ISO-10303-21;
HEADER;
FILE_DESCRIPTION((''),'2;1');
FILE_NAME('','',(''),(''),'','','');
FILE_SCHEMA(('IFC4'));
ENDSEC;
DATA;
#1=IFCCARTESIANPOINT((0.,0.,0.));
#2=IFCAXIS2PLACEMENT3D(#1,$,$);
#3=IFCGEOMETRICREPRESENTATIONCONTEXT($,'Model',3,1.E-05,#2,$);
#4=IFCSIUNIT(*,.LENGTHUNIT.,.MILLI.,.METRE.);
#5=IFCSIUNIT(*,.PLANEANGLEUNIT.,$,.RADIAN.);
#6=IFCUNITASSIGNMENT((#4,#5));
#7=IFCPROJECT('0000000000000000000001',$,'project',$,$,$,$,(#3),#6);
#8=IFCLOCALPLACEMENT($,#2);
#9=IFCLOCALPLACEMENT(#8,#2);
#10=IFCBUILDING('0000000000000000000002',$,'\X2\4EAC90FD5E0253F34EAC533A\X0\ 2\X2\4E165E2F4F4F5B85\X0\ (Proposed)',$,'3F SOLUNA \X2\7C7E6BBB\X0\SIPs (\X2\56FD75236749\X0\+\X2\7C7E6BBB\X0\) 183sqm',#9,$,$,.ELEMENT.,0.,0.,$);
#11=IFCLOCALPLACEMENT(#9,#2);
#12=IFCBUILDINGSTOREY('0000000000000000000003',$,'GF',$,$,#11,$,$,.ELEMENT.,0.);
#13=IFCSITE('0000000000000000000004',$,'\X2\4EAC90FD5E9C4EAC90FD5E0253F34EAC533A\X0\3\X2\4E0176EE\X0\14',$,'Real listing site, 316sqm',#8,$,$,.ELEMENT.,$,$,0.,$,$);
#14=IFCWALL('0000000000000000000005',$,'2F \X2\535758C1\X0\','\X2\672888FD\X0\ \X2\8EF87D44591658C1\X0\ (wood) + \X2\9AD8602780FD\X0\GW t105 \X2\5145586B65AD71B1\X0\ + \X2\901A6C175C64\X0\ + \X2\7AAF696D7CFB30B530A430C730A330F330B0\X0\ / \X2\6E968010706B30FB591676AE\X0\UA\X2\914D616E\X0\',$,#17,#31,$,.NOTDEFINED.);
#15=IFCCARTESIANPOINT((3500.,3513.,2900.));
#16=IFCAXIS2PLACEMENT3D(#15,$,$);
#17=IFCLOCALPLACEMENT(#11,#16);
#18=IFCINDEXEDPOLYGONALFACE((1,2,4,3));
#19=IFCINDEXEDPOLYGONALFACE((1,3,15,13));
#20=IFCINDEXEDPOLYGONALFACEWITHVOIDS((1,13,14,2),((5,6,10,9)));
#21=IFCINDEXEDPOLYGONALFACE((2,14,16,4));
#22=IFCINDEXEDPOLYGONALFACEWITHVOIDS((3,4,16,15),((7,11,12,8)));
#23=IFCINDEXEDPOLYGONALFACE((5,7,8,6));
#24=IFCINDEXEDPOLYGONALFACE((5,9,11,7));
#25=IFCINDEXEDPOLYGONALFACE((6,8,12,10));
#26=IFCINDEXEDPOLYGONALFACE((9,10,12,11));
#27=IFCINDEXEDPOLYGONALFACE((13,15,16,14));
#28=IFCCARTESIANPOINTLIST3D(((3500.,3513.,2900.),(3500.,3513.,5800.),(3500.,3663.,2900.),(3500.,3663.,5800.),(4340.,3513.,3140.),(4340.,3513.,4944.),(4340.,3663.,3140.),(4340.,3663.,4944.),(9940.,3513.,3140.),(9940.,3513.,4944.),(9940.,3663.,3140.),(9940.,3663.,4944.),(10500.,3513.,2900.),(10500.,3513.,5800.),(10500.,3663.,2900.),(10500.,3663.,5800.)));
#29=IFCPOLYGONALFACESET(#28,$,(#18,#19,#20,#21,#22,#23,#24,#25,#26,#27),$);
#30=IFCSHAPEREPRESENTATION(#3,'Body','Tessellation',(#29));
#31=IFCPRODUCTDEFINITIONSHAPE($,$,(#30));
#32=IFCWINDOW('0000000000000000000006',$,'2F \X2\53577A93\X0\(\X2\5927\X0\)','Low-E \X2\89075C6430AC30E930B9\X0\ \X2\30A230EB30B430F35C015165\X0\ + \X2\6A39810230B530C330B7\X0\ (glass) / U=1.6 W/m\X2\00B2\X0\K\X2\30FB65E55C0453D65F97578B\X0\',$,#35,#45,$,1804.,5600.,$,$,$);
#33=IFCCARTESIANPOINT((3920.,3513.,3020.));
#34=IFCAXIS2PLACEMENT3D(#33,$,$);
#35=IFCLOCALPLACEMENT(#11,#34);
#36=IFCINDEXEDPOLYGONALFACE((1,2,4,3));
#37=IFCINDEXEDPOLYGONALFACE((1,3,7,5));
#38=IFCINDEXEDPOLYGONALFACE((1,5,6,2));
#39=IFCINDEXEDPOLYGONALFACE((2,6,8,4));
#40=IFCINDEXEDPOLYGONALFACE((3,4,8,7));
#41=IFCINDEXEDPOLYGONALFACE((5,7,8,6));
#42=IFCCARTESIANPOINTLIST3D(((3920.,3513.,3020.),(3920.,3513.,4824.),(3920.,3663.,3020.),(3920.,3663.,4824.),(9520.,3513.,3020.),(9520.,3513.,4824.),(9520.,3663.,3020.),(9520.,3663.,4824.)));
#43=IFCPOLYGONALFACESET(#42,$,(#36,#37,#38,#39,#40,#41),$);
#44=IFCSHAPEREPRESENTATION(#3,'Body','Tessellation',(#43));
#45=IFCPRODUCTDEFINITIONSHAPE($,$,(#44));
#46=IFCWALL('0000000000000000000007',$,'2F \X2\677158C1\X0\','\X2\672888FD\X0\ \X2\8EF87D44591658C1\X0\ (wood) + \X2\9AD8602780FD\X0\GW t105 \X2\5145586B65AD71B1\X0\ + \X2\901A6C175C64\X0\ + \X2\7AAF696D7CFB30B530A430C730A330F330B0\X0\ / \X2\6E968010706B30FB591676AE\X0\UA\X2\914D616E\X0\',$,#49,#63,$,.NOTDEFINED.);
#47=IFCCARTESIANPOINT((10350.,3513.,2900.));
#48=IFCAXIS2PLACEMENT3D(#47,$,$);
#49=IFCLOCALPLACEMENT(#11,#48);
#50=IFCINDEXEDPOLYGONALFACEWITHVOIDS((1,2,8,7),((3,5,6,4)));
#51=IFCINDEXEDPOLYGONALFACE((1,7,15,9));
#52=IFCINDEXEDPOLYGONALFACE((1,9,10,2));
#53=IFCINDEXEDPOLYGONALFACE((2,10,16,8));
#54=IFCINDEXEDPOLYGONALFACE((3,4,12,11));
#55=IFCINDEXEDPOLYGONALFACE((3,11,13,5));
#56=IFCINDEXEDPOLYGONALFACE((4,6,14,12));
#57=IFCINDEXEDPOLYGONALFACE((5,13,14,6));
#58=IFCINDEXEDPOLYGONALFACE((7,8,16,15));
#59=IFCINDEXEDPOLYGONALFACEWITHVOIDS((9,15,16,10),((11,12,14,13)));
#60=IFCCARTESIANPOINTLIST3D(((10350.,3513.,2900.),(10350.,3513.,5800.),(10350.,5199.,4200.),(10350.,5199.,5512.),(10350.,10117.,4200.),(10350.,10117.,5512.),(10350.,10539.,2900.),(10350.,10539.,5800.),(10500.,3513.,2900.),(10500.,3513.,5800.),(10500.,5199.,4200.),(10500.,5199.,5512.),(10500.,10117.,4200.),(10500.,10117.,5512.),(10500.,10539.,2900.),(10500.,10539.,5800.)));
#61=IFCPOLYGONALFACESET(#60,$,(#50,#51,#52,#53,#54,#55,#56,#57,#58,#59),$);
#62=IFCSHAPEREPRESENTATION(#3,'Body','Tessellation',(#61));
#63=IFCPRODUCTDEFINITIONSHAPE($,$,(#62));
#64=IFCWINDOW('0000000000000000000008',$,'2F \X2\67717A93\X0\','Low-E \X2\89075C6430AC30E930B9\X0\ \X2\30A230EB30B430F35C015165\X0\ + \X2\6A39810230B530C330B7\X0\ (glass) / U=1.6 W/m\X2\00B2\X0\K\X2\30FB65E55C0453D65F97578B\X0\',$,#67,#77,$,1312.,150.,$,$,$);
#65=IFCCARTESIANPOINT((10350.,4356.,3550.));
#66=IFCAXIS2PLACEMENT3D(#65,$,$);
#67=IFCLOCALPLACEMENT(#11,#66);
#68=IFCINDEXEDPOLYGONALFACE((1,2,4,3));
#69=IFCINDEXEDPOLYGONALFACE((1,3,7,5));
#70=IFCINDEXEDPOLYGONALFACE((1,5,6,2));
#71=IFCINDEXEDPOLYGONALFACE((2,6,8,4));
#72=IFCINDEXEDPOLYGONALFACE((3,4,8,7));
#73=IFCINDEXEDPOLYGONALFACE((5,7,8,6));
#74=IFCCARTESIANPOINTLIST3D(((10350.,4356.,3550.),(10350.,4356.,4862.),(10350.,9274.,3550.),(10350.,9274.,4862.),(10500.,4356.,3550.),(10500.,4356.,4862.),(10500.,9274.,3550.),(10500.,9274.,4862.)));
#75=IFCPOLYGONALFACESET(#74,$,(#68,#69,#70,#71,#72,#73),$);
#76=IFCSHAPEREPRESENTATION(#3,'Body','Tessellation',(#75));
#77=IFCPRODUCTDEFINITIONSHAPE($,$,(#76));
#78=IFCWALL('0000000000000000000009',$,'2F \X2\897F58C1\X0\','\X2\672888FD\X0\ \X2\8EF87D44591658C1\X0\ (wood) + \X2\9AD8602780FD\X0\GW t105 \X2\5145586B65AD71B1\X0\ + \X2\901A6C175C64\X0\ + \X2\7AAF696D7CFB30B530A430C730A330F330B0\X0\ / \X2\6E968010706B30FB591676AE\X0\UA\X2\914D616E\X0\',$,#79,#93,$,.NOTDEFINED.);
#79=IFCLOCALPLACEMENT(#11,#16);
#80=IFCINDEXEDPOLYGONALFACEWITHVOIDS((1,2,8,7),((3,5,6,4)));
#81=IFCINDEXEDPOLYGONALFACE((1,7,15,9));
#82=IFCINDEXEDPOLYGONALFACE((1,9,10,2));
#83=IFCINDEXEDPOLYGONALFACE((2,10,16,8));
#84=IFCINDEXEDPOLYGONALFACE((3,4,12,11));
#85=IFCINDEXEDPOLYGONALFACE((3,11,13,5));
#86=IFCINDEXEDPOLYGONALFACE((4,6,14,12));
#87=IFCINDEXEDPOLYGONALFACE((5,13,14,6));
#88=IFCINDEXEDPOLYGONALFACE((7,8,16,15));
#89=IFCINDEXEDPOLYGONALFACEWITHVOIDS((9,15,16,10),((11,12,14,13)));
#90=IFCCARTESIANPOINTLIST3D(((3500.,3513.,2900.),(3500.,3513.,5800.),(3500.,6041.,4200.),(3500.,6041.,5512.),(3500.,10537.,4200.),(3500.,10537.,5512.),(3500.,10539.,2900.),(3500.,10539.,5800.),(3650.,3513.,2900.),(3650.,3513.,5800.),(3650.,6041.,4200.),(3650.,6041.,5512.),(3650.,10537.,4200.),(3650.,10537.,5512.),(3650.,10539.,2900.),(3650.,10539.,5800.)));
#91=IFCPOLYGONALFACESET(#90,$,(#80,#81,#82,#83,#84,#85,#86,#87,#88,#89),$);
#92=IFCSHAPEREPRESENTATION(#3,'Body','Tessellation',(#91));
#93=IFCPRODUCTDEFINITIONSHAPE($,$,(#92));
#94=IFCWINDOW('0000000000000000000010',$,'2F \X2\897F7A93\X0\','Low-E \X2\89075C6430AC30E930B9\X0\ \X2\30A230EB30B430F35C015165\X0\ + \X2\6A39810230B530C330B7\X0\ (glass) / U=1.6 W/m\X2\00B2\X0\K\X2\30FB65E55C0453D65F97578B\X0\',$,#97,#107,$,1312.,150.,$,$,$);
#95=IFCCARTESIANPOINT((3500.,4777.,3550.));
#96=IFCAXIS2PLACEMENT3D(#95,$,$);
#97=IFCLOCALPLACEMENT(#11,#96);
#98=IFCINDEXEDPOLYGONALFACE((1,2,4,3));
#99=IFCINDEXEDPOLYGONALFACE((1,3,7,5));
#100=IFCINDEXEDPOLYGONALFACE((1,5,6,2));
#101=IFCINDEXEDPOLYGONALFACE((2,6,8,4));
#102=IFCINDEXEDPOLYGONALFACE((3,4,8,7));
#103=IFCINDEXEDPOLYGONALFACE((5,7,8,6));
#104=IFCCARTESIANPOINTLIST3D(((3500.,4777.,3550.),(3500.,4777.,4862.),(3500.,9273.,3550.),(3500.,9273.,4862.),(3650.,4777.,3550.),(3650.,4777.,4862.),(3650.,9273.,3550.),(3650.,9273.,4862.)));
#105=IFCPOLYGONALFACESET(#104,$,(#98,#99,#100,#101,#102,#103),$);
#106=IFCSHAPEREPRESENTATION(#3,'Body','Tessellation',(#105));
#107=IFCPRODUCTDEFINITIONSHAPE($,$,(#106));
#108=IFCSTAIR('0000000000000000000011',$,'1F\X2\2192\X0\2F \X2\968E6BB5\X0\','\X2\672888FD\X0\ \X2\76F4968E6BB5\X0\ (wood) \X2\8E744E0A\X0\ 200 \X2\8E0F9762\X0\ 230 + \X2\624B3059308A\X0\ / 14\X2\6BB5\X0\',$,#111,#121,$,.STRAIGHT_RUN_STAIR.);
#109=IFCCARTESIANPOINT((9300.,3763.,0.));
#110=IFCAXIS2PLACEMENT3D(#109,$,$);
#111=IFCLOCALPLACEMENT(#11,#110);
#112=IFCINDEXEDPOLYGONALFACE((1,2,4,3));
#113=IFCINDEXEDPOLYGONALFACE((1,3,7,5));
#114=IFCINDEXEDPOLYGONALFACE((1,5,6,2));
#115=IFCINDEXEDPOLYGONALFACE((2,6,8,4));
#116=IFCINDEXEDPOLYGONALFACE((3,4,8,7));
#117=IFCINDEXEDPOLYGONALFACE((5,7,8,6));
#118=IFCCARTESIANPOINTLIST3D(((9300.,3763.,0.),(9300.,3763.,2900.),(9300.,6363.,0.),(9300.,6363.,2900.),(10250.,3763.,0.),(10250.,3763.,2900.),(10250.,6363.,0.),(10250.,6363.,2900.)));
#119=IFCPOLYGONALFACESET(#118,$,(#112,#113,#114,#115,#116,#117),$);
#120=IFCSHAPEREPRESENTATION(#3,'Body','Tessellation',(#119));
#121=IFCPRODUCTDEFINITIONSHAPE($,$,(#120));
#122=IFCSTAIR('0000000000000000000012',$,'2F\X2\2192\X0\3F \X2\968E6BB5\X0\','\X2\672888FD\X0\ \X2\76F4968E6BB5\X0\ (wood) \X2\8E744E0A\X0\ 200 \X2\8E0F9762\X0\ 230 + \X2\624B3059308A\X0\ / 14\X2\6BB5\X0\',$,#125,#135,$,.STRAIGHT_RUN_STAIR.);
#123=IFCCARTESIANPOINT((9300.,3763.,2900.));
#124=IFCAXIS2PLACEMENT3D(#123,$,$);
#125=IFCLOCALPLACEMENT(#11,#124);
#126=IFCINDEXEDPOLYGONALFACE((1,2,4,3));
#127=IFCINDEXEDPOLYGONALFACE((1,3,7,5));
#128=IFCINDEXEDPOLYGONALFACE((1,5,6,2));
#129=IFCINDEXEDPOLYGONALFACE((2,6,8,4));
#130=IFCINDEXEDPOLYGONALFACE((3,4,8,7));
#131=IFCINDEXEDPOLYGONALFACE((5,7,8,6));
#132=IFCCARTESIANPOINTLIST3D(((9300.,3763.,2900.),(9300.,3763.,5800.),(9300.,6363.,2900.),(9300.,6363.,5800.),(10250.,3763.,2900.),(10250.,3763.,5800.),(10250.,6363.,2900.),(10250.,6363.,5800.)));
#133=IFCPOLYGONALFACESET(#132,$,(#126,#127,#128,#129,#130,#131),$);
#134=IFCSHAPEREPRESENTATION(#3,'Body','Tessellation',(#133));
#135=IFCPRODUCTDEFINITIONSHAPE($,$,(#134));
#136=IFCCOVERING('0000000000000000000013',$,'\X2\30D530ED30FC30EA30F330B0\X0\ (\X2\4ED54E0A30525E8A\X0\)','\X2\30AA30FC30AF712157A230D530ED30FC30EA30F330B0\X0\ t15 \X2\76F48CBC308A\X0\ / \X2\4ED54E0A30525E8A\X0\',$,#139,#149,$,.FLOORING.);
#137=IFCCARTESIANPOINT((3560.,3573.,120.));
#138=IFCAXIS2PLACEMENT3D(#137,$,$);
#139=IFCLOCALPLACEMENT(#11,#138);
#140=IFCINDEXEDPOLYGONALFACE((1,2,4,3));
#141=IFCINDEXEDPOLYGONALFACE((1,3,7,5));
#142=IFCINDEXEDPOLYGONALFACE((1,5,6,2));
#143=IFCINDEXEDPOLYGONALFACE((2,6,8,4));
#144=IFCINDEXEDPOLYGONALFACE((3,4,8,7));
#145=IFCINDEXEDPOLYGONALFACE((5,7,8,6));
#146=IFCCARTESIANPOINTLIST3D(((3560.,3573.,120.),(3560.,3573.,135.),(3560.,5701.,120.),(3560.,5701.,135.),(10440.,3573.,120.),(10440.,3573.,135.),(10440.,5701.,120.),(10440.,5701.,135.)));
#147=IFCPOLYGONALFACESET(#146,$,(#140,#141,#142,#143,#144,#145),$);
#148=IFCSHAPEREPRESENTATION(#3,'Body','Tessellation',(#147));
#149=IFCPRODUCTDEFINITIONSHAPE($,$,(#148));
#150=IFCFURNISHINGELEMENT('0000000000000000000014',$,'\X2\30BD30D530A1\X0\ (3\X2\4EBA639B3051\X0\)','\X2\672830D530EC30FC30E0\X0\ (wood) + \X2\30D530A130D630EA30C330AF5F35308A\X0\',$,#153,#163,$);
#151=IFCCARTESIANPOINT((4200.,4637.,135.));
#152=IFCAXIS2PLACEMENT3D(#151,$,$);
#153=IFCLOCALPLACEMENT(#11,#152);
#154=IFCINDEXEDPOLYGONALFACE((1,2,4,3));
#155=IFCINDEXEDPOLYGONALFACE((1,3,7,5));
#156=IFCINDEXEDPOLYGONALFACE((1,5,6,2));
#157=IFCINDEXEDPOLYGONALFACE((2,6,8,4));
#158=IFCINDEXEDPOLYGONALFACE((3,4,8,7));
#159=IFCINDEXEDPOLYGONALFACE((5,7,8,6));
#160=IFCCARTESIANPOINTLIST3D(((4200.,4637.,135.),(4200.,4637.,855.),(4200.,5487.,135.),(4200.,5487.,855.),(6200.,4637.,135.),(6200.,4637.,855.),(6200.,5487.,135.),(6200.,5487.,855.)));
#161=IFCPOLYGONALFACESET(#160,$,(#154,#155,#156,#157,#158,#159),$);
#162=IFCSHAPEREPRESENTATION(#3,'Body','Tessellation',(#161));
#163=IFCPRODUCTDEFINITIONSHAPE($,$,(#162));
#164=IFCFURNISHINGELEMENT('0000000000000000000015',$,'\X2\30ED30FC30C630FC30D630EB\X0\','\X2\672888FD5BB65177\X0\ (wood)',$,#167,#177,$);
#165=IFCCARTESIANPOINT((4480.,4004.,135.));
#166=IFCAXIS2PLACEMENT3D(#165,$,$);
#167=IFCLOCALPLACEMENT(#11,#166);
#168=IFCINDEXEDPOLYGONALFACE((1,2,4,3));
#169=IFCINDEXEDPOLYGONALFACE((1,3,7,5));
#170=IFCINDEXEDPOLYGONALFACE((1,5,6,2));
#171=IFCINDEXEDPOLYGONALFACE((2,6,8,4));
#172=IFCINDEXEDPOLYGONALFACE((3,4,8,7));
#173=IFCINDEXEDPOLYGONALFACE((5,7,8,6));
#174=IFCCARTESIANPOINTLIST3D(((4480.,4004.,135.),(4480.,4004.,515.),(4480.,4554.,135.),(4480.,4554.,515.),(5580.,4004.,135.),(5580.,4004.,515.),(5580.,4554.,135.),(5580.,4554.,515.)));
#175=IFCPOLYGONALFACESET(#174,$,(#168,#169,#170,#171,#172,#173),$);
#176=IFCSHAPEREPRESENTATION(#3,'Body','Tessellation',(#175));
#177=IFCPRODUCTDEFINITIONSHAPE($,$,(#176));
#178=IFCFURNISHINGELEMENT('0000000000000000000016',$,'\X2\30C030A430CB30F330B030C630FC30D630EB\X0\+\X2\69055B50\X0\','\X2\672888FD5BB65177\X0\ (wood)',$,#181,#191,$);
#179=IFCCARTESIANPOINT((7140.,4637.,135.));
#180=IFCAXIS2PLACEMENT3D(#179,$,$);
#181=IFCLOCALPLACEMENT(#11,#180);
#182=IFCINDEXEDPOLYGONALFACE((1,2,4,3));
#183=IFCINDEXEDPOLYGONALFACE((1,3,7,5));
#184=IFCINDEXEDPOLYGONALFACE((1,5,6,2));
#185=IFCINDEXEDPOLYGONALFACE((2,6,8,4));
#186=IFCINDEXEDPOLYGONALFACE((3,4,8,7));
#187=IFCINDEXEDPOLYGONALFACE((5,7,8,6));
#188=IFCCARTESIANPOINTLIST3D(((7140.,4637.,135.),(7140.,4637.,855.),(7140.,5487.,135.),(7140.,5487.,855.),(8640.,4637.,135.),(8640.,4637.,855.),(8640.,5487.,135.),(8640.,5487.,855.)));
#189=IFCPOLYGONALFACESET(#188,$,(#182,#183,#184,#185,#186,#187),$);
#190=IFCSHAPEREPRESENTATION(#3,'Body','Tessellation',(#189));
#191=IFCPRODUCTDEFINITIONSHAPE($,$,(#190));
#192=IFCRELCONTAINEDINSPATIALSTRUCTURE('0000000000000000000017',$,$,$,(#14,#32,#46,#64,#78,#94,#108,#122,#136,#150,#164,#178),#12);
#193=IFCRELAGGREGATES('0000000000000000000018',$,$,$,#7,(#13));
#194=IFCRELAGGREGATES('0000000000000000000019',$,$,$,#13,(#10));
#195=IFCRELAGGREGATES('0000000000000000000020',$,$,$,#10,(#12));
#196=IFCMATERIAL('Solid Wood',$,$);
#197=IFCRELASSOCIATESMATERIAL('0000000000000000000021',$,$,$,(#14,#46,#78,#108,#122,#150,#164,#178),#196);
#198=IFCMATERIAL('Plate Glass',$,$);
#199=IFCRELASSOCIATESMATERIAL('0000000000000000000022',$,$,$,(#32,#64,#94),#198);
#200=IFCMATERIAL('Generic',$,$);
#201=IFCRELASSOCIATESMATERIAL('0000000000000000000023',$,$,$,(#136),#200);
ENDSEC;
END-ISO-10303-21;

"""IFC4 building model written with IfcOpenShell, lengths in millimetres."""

from ifc_helpers import new_model, si_unit, frame, frame_2d, origin, place, context, project, spatial, rectangle, extrude, material, element, fill, save


model = new_model("IFC4")

# Units and contexts
model_context = context("Model", 3, precision=1e-05, world=origin())
ifc_project = project(units=[si_unit("LENGTHUNIT", "METRE", prefix="MILLI"), si_unit("PLANEANGLEUNIT", "RADIAN")], contexts=[model_context])

# Site, building, storey
site_placement = place(None, origin())
site = spatial("IfcSite", under=ifc_project, at=site_placement, Name="京都府京都市右京区3丁目14", ObjectType="Real listing site, 316sqm", CompositionType="ELEMENT", RefElevation=0.0)
building_placement = place(site_placement, origin())
building = spatial("IfcBuilding", under=site, at=building_placement, Name="京都市右京区 2世帯住宅 (Proposed)", ObjectType="3F SOLUNA 籾殻SIPs (国産杉+籾殻) 183sqm", CompositionType="ELEMENT", ElevationOfRefHeight=0.0, ElevationOfTerrain=0.0)
storey_placement = place(building_placement, origin())
storey = spatial("IfcBuildingStorey", under=building, at=storey_placement, Name="GF", CompositionType="ELEMENT", Elevation=0.0)

# Shared definitions
ifc_material_1 = material(Name="Solid Wood")

# Shared definitions
ifc_material_2 = material(Name="Plate Glass")

# Walls, openings, windows
wall_1_placement = place(storey_placement, frame((3500.0, 3513.0, 2900.0)))
wall_1 = element("IfcWall", 1, at=wall_1_placement, inside=storey, material=ifc_material_1, Name="2F 南壁", Description="木製 軸組外壁 (wood) + 高性能GW t105 充填断熱 + 通気層 + 窯業系サイディング / 準耐火・外皮UA配慮", PredefinedType="NOTDEFINED", context=model_context, shape_type="SweptSolid", body=[
    extrude(rectangle(XDim=7000.0, YDim=150.0, at=frame_2d((3500.0, 75.0))), frame((3500.0, 3513.0, 2900.0)), (0.0, 0.0, 1.0), 2900.0),
])
opening_1_placement = place(storey_placement, frame((3920.0, 3513.0, 3020.0)))
opening_1 = element("IfcOpeningElement", 2, at=opening_1_placement, cuts=wall_1, PredefinedType="NOTDEFINED", context=model_context, shape_type="SweptSolid", body=[
    extrude(rectangle(XDim=5600.0, YDim=150.0, at=frame_2d((2800.0, 75.0))), frame((3920.0, 3513.0, 3020.0)), (0.0, 0.0, 1.0), 1804.0),
])
window_1_placement = place(storey_placement, frame((3920.0, 3513.0, 3020.0)))
window_1 = element("IfcWindow", 3, at=window_1_placement, inside=storey, material=ifc_material_2, Name="2F 南窓(大)", Description="Low-E 複層ガラス アルゴン封入 + 樹脂サッシ (glass) / U=1.6 W/m²K・日射取得型", OverallHeight=1804.0, OverallWidth=5600.0, context=model_context, shape_type="SweptSolid", body=[
    extrude(rectangle(XDim=5600.0, YDim=150.0, at=frame_2d((2800.0, 75.0))), frame((3920.0, 3513.0, 3020.0)), (0.0, 0.0, 1.0), 1804.0),
])
fill(opening_1, window_1)
wall_2_placement = place(storey_placement, frame((10350.0, 3513.0, 2900.0)))
wall_2 = element("IfcWall", 4, at=wall_2_placement, inside=storey, material=ifc_material_1, Name="2F 東壁", Description="木製 軸組外壁 (wood) + 高性能GW t105 充填断熱 + 通気層 + 窯業系サイディング / 準耐火・外皮UA配慮", PredefinedType="NOTDEFINED", context=model_context, shape_type="SweptSolid", body=[
    extrude(rectangle(XDim=150.0, YDim=7026.0, at=frame_2d((75.0, 3513.0))), frame((10350.0, 3513.0, 2900.0)), (0.0, 0.0, 1.0), 2900.0),
])
opening_2_placement = place(storey_placement, frame((10350.0, 4356.0, 3550.0)))
opening_2 = element("IfcOpeningElement", 5, at=opening_2_placement, cuts=wall_2, PredefinedType="NOTDEFINED", context=model_context, shape_type="SweptSolid", body=[
    extrude(rectangle(XDim=150.0, YDim=4918.0, at=frame_2d((75.0, 2459.0))), frame((10350.0, 4356.0, 3550.0)), (0.0, 0.0, 1.0), 1312.0),
])
window_2_placement = place(storey_placement, frame((10350.0, 4356.0, 3550.0)))
window_2 = element("IfcWindow", 6, at=window_2_placement, inside=storey, material=ifc_material_2, Name="2F 東窓", Description="Low-E 複層ガラス アルゴン封入 + 樹脂サッシ (glass) / U=1.6 W/m²K・日射取得型", OverallHeight=1312.0, OverallWidth=150.0, context=model_context, shape_type="SweptSolid", body=[
    extrude(rectangle(XDim=150.0, YDim=4918.0, at=frame_2d((75.0, 2459.0))), frame((10350.0, 4356.0, 3550.0)), (0.0, 0.0, 1.0), 1312.0),
])
fill(opening_2, window_2)
wall_3_placement = place(storey_placement, frame((3500.0, 3513.0, 2900.0)))
wall_3 = element("IfcWall", 7, at=wall_3_placement, inside=storey, material=ifc_material_1, Name="2F 西壁", Description="木製 軸組外壁 (wood) + 高性能GW t105 充填断熱 + 通気層 + 窯業系サイディング / 準耐火・外皮UA配慮", PredefinedType="NOTDEFINED", context=model_context, shape_type="SweptSolid", body=[
    extrude(rectangle(XDim=150.0, YDim=7026.0, at=frame_2d((75.0, 3513.0))), frame((3500.0, 3513.0, 2900.0)), (0.0, 0.0, 1.0), 2900.0),
])
opening_3_placement = place(storey_placement, frame((3500.0, 4777.0, 3550.0)))
opening_3 = element("IfcOpeningElement", 8, at=opening_3_placement, cuts=wall_3, PredefinedType="NOTDEFINED", context=model_context, shape_type="SweptSolid", body=[
    extrude(rectangle(XDim=150.0, YDim=4496.0, at=frame_2d((75.0, 2248.0))), frame((3500.0, 4777.0, 3550.0)), (0.0, 0.0, 1.0), 1312.0),
])
window_3_placement = place(storey_placement, frame((3500.0, 4777.0, 3550.0)))
window_3 = element("IfcWindow", 9, at=window_3_placement, inside=storey, material=ifc_material_2, Name="2F 西窓", Description="Low-E 複層ガラス アルゴン封入 + 樹脂サッシ (glass) / U=1.6 W/m²K・日射取得型", OverallHeight=1312.0, OverallWidth=150.0, context=model_context, shape_type="SweptSolid", body=[
    extrude(rectangle(XDim=150.0, YDim=4496.0, at=frame_2d((75.0, 2248.0))), frame((3500.0, 4777.0, 3550.0)), (0.0, 0.0, 1.0), 1312.0),
])
fill(opening_3, window_3)

# Stairs
stair_1_placement = place(storey_placement, frame((9300.0, 3763.0, 0.0)))
element("IfcStair", 10, at=stair_1_placement, inside=storey, material=ifc_material_1, Name="1F→2F 階段", Description="木製 直階段 (wood) 蹴上 200 踏面 230 + 手すり / 14段", PredefinedType="STRAIGHT_RUN_STAIR", context=model_context, shape_type="SweptSolid", body=[
    extrude(rectangle(XDim=950.0, YDim=2600.0, at=frame_2d((475.0, 1300.0))), frame((9300.0, 3763.0, 0.0)), (0.0, 0.0, 1.0), 2900.0),
])
stair_2_placement = place(storey_placement, frame((9300.0, 3763.0, 2900.0)))
element("IfcStair", 11, at=stair_2_placement, inside=storey, material=ifc_material_1, Name="2F→3F 階段", Description="木製 直階段 (wood) 蹴上 200 踏面 230 + 手すり / 14段", PredefinedType="STRAIGHT_RUN_STAIR", context=model_context, shape_type="SweptSolid", body=[
    extrude(rectangle(XDim=950.0, YDim=2600.0, at=frame_2d((475.0, 1300.0))), frame((9300.0, 3763.0, 2900.0)), (0.0, 0.0, 1.0), 2900.0),
])

# Covering
ifc_material_3 = material(Name="Generic")
covering_placement = place(storey_placement, frame((3560.0, 3573.0, 120.0)))
element("IfcCovering", 12, at=covering_placement, inside=storey, material=ifc_material_3, Name="フローリング (仕上げ床)", Description="オーク無垢フローリング t15 直貼り / 仕上げ床", PredefinedType="FLOORING", context=model_context, shape_type="SweptSolid", body=[
    extrude(rectangle(XDim=6880.0, YDim=2128.0, at=frame_2d((3440.0, 1064.0))), frame((3560.0, 3573.0, 120.0)), (0.0, 0.0, 1.0), 15.0),
])

# Furnishing elements
furnishing_1_placement = place(storey_placement, frame((4200.0, 4637.0, 135.0)))
element("IfcFurnishingElement", 13, at=furnishing_1_placement, inside=storey, material=ifc_material_1, Name="ソファ (3人掛け)", Description="木フレーム (wood) + ファブリック張り", context=model_context, shape_type="SweptSolid", body=[
    extrude(rectangle(XDim=2000.0, YDim=850.0, at=frame_2d((1000.0, 425.0))), frame((4200.0, 4637.0, 135.0)), (0.0, 0.0, 1.0), 720.0),
])
furnishing_2_placement = place(storey_placement, frame((4480.0, 4004.0, 135.0)))
element("IfcFurnishingElement", 14, at=furnishing_2_placement, inside=storey, material=ifc_material_1, Name="ローテーブル", Description="木製家具 (wood)", context=model_context, shape_type="SweptSolid", body=[
    extrude(rectangle(XDim=1100.0, YDim=550.0, at=frame_2d((550.0, 275.0))), frame((4480.0, 4004.0, 135.0)), (0.0, 0.0, 1.0), 380.0),
])
furnishing_3_placement = place(storey_placement, frame((7140.0, 4637.0, 135.0)))
element("IfcFurnishingElement", 15, at=furnishing_3_placement, inside=storey, material=ifc_material_1, Name="ダイニングテーブル+椅子", Description="木製家具 (wood)", context=model_context, shape_type="SweptSolid", body=[
    extrude(rectangle(XDim=1500.0, YDim=850.0, at=frame_2d((750.0, 425.0))), frame((7140.0, 4637.0, 135.0)), (0.0, 0.0, 1.0), 720.0),
])

save(model, "model.ifc")
